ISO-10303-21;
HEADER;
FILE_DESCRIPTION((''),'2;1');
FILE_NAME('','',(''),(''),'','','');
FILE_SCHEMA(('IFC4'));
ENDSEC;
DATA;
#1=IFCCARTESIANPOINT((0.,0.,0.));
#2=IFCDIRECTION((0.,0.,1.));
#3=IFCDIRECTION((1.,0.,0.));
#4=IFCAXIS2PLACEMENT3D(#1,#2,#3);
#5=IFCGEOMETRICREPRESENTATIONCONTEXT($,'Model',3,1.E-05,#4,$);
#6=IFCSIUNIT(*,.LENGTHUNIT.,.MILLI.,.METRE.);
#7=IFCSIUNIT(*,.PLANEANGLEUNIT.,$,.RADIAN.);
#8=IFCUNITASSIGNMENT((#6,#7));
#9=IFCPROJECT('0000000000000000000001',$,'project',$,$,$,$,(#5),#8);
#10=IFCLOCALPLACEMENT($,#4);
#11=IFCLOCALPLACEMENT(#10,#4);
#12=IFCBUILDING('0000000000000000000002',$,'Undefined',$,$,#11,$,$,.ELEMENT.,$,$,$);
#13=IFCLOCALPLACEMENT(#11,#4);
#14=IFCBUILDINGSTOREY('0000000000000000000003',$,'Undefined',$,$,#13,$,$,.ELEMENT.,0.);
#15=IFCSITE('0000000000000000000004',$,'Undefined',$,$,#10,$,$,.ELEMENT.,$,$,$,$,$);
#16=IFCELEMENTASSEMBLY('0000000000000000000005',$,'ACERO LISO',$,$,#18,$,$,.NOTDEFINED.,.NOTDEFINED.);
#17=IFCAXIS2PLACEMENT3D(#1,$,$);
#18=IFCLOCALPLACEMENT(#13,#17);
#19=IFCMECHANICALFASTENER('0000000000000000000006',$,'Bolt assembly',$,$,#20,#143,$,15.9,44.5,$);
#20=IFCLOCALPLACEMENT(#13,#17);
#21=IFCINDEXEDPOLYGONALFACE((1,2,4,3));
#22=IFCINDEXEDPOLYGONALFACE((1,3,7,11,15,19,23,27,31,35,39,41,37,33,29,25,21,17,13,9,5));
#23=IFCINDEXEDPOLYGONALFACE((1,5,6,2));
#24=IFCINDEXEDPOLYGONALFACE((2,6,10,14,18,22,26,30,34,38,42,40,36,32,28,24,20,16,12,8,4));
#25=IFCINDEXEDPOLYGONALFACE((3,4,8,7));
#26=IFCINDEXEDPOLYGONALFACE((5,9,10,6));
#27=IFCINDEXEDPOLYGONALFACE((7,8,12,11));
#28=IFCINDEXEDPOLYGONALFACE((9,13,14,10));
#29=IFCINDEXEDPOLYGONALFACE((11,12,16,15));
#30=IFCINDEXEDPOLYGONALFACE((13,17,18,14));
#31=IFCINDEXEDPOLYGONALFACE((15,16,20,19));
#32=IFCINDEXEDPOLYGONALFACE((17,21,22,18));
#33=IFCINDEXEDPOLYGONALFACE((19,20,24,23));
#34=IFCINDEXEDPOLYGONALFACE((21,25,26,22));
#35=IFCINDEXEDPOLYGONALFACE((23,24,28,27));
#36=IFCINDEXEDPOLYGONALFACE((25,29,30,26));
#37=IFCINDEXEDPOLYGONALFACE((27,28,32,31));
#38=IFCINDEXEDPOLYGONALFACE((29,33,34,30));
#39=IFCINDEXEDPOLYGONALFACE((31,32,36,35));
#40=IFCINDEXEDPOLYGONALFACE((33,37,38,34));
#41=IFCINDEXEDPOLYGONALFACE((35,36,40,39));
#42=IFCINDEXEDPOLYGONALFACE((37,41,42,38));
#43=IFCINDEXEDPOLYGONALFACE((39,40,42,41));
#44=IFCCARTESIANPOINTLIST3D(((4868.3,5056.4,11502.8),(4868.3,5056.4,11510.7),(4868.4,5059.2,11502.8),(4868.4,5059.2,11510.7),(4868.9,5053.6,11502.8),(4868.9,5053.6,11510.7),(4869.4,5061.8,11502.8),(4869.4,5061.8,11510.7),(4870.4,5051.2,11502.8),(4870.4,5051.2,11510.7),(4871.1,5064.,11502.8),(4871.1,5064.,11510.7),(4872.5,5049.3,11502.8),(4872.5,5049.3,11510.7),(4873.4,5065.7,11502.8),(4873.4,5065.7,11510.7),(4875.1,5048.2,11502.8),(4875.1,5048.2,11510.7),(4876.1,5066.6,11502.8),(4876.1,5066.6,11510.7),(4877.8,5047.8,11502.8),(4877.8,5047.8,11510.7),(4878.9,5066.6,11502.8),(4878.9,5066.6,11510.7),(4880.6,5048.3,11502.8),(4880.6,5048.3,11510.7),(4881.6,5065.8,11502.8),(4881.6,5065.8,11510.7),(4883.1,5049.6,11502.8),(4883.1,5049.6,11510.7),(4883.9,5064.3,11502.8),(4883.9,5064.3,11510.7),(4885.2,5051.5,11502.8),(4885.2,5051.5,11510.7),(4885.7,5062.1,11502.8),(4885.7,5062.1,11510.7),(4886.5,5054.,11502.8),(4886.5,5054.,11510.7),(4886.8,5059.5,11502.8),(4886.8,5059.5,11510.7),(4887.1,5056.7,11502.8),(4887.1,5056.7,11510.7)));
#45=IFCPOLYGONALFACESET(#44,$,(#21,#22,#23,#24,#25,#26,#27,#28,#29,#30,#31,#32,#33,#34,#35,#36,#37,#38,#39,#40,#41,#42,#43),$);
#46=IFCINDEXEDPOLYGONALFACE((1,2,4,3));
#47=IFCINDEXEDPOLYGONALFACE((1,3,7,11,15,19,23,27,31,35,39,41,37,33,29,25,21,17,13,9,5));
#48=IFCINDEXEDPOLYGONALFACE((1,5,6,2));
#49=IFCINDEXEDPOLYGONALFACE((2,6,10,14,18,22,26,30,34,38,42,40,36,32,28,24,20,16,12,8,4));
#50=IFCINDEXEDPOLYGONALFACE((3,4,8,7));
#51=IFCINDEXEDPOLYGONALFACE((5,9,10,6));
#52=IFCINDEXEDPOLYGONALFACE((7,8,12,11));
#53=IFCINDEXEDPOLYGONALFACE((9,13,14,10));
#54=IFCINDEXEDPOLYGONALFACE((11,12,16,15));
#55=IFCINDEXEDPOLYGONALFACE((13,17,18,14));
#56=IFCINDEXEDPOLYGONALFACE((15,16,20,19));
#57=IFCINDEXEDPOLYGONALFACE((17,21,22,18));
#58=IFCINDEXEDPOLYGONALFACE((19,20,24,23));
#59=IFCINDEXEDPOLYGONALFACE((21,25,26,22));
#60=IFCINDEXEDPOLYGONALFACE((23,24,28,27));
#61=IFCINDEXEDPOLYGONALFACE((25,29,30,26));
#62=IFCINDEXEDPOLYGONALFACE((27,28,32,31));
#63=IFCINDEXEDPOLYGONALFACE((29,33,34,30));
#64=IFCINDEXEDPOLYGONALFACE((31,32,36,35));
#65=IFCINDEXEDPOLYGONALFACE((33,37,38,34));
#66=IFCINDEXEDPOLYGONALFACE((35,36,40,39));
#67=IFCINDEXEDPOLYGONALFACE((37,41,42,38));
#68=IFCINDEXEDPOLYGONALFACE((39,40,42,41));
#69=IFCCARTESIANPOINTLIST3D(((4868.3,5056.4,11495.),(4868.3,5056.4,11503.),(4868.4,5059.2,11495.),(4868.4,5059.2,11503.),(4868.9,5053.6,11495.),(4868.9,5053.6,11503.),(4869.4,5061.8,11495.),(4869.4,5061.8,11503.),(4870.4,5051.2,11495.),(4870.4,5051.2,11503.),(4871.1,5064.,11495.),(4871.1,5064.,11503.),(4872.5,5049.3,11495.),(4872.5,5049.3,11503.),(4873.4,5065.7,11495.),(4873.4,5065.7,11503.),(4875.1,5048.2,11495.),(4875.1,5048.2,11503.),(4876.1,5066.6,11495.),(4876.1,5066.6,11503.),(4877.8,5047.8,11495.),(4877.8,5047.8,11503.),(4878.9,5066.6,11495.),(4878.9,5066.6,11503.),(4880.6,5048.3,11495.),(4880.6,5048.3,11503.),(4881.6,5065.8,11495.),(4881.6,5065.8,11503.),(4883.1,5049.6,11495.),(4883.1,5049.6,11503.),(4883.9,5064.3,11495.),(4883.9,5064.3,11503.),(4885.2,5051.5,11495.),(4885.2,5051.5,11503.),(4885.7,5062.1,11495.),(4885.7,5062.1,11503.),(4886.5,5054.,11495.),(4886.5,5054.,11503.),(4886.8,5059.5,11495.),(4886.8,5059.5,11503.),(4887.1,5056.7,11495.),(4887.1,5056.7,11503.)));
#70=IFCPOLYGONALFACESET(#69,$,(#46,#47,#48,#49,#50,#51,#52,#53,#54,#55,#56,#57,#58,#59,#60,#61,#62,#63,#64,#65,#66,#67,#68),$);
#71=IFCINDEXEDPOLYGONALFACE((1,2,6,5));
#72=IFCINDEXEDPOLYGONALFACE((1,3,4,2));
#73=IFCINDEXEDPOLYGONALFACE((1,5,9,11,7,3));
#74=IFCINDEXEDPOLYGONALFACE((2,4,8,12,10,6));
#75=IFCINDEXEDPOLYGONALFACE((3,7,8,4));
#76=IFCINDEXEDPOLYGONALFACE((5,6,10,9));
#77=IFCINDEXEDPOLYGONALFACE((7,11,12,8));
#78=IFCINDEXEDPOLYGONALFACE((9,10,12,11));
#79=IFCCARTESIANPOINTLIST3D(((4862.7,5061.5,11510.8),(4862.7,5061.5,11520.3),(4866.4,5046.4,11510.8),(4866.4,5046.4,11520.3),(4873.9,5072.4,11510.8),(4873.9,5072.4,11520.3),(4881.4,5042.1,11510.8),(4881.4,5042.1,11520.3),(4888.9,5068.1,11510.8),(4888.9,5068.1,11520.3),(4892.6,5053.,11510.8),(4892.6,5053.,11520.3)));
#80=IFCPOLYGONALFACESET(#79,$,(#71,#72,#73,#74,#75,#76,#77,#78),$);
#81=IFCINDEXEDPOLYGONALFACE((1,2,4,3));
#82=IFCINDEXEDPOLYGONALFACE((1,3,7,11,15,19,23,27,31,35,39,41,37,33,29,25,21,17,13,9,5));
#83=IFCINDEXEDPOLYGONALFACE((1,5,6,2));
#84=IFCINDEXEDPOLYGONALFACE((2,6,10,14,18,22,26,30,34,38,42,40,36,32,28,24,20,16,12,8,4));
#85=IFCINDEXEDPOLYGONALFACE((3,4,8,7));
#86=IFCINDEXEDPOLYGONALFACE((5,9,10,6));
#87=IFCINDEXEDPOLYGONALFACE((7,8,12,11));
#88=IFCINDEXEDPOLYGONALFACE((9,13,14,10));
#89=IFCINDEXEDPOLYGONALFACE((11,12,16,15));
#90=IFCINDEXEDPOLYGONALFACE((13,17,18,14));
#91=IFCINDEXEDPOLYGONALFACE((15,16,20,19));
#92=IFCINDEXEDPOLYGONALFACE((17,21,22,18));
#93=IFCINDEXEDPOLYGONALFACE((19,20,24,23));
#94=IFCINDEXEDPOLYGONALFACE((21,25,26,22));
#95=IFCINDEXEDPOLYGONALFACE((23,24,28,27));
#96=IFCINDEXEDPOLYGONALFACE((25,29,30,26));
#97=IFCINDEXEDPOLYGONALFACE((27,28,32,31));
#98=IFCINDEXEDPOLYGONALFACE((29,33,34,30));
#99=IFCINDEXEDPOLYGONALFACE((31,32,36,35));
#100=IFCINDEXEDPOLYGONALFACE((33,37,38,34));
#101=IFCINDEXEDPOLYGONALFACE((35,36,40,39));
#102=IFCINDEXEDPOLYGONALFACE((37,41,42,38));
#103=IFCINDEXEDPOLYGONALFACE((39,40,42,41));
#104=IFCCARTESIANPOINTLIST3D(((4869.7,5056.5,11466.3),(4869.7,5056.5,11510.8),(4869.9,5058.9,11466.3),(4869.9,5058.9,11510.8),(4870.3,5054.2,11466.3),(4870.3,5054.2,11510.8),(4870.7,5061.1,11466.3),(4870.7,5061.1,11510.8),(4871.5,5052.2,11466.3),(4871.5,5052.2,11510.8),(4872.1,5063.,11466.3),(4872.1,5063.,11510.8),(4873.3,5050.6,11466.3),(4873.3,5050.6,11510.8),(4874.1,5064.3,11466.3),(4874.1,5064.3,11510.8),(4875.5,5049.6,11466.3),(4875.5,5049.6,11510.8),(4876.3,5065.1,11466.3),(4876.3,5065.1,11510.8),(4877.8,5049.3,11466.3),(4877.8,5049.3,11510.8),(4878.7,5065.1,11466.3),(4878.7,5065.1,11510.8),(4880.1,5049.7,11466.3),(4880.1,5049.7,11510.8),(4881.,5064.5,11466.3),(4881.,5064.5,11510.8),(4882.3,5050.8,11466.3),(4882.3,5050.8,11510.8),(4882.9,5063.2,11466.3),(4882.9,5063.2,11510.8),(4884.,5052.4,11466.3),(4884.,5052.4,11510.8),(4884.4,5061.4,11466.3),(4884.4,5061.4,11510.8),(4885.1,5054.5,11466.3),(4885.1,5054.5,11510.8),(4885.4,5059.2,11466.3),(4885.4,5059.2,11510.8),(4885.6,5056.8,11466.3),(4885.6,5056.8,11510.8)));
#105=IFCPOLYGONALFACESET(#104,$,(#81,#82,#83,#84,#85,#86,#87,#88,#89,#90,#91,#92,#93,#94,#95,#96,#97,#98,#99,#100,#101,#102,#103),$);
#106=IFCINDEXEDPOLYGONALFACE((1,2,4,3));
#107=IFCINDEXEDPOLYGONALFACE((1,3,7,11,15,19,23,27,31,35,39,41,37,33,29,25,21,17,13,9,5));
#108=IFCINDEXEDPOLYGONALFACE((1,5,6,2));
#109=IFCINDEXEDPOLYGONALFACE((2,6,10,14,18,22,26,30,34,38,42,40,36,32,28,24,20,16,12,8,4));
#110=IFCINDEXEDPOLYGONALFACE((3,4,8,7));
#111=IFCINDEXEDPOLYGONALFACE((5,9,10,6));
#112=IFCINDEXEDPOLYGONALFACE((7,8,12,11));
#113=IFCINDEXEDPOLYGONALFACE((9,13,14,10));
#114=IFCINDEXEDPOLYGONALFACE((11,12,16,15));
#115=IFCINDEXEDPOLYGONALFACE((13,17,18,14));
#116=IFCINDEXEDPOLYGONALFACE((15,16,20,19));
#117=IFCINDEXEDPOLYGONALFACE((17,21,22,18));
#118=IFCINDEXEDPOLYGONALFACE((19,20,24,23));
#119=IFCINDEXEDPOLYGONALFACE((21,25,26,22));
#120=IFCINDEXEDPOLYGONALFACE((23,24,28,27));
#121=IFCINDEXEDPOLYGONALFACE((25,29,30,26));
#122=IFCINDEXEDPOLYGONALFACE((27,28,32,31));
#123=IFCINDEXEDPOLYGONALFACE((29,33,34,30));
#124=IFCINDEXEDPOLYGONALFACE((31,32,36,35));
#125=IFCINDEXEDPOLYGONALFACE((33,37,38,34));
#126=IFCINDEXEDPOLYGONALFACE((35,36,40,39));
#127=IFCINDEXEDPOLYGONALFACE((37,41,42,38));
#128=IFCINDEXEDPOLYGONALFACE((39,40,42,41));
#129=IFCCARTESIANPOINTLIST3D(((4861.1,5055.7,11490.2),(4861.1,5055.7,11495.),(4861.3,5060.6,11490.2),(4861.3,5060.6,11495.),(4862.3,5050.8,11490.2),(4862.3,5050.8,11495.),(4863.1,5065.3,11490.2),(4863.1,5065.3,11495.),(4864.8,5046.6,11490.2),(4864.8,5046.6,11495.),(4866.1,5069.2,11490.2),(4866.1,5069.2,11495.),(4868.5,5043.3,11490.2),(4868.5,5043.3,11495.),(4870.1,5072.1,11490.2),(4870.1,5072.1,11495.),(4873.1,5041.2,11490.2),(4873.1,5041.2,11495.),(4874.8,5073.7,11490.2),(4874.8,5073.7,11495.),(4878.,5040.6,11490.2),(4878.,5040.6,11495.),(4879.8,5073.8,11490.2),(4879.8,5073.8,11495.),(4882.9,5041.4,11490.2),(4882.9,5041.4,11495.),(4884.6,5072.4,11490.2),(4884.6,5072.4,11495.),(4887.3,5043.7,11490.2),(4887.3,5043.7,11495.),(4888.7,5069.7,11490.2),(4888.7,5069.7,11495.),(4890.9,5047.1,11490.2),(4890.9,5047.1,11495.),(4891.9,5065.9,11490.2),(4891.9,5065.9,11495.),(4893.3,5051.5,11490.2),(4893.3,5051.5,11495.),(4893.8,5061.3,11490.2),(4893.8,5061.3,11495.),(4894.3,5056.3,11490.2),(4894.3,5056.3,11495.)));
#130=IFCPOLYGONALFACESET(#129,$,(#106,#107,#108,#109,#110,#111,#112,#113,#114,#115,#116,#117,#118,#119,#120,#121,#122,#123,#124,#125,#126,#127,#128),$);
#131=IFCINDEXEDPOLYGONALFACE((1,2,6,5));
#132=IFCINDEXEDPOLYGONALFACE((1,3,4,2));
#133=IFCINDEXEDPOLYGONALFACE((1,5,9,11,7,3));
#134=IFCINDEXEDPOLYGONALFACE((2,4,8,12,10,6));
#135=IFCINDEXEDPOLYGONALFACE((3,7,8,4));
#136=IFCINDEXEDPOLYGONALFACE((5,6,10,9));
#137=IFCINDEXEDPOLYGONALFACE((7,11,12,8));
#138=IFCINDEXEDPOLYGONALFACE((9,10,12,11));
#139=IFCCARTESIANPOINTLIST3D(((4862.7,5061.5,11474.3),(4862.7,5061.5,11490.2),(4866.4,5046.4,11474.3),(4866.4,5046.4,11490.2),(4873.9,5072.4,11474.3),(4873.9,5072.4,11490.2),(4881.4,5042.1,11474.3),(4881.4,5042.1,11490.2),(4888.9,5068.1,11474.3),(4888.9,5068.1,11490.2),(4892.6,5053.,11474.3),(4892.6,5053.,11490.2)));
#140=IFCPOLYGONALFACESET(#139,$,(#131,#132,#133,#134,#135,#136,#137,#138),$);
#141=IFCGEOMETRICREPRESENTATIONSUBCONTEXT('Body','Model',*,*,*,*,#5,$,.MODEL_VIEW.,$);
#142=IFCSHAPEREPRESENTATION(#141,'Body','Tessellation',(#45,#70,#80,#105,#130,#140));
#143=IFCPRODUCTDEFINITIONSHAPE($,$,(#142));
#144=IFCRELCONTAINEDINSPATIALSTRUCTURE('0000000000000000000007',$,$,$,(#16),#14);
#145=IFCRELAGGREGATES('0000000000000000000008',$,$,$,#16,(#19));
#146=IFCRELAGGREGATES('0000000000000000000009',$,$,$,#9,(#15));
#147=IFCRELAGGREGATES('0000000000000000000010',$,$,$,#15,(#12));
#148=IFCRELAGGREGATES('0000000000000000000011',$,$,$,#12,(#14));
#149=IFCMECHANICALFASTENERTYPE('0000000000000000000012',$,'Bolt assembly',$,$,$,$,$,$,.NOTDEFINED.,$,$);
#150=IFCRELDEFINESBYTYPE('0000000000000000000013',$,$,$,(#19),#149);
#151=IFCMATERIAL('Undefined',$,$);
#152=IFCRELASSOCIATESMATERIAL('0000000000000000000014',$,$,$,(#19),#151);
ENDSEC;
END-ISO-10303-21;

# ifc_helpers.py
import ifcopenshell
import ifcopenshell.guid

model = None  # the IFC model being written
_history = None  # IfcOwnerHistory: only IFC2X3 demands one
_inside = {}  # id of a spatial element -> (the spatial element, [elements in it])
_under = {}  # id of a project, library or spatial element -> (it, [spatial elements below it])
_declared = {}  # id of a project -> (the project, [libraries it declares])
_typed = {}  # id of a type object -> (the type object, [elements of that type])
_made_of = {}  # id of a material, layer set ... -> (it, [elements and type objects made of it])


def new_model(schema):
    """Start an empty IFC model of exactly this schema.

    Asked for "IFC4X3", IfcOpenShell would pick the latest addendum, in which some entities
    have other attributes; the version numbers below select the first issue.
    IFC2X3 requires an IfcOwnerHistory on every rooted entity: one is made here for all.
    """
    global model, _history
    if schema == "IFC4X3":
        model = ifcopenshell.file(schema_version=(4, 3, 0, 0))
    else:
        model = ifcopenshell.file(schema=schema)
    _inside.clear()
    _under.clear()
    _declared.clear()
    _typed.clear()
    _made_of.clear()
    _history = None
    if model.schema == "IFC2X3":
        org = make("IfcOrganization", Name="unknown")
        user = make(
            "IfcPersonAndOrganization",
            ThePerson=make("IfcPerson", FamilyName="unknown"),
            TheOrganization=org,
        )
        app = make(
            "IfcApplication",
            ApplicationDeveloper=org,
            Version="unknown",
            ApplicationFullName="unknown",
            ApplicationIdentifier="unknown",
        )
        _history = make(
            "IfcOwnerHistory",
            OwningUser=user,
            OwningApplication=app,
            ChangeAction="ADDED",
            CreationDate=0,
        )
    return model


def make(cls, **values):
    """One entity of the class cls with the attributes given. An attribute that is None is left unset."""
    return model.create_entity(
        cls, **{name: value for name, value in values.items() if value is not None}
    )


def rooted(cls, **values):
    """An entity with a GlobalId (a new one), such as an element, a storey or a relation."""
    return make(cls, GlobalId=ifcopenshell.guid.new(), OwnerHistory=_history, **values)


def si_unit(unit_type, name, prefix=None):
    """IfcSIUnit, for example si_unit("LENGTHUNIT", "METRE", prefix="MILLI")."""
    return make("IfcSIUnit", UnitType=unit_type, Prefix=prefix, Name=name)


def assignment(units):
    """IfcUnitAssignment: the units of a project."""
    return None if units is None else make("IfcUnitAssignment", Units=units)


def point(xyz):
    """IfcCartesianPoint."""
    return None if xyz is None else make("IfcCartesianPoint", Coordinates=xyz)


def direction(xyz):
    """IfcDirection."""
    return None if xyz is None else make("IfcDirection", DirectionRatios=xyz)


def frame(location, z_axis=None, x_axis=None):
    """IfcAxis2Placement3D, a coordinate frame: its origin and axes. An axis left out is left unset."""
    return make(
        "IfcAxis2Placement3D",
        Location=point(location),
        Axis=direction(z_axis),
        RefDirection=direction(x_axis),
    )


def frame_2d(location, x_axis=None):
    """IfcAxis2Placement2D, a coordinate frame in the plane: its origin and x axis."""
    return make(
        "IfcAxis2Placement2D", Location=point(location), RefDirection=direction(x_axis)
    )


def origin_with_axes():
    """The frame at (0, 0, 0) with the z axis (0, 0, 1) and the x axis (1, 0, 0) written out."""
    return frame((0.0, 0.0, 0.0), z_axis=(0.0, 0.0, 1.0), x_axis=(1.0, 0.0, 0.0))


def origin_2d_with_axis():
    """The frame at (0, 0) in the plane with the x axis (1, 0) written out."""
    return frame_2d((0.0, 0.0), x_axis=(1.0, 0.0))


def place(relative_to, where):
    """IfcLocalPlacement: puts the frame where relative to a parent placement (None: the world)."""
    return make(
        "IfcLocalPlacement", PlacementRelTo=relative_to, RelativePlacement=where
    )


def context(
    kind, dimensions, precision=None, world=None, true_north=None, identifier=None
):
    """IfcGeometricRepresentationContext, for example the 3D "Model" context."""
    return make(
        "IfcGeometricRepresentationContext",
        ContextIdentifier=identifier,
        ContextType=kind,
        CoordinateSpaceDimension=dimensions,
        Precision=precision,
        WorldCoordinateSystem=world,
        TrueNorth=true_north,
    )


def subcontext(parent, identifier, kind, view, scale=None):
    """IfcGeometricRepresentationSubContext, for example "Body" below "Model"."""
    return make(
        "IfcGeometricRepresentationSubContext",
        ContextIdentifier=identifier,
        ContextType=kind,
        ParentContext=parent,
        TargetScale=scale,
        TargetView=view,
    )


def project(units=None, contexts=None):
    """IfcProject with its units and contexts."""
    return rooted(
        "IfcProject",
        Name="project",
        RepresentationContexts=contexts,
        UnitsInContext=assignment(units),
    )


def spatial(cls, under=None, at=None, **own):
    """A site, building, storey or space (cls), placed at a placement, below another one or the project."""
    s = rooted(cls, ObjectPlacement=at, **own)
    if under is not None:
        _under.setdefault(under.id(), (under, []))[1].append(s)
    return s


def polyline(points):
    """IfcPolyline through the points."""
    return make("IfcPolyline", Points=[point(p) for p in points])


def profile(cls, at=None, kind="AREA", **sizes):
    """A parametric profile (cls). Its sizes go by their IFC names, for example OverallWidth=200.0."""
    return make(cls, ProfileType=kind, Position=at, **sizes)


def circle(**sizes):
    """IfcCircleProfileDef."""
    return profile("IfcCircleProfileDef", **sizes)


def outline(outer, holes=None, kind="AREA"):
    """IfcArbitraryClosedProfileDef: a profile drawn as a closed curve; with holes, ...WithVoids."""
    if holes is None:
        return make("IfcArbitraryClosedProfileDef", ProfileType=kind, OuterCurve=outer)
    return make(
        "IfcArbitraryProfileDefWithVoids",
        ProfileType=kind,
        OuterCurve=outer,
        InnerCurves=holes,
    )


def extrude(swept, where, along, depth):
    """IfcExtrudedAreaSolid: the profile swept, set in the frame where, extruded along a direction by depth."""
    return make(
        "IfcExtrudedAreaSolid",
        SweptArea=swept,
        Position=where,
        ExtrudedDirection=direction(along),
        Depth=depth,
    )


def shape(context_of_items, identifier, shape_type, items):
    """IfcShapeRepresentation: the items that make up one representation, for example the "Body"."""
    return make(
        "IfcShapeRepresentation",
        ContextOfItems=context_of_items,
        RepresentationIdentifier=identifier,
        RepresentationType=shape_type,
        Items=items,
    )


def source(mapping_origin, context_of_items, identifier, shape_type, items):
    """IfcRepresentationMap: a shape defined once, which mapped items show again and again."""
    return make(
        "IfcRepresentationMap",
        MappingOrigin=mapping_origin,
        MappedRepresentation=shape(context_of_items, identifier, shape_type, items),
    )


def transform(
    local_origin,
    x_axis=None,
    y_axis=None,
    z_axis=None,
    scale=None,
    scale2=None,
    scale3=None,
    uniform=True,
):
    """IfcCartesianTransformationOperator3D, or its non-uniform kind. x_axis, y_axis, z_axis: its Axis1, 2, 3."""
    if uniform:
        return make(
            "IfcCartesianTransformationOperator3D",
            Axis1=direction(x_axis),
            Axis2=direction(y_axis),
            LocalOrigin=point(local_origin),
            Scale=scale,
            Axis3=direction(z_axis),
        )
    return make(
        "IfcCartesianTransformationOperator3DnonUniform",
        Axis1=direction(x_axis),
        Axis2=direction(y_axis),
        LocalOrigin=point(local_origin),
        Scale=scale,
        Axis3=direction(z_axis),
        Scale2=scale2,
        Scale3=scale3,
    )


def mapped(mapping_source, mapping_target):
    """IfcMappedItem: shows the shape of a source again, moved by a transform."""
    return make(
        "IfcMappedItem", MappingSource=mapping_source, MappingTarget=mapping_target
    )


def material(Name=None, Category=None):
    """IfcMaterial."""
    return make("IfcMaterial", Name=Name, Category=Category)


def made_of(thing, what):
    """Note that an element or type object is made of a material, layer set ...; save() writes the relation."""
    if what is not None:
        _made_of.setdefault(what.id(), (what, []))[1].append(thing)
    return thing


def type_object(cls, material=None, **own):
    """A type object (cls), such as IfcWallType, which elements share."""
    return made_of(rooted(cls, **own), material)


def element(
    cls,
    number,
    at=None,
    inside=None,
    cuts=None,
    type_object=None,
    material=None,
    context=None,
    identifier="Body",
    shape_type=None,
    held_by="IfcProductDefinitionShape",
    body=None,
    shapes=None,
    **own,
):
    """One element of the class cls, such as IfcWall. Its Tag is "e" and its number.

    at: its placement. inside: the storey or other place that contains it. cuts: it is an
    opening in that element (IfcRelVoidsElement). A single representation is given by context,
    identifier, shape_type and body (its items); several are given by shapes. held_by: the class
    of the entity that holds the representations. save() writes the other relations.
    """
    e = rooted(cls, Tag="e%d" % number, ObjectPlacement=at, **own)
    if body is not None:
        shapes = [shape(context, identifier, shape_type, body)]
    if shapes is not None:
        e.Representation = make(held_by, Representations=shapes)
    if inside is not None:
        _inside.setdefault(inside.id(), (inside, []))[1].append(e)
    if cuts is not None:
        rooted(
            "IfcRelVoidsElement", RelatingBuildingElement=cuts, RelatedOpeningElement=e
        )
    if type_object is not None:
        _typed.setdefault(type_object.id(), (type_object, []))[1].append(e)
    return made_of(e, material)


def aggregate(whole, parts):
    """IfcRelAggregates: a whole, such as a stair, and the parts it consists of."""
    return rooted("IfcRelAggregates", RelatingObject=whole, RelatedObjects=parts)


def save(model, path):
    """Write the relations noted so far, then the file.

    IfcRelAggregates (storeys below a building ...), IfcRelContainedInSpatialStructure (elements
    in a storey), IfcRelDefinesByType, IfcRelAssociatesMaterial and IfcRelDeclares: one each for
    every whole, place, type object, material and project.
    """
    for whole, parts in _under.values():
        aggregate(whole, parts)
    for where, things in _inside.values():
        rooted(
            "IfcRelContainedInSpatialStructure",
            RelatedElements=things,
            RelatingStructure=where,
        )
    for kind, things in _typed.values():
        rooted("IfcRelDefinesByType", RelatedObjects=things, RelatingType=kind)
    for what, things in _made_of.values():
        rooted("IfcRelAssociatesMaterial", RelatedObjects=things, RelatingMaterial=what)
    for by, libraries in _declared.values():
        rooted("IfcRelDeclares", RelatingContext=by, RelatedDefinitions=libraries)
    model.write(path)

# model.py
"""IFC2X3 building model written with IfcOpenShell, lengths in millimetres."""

from ifc_helpers import new_model, si_unit, frame, origin_with_axes, origin_2d_with_axis, place, context, subcontext, project, spatial, polyline, circle, outline, extrude, source, transform, mapped, material, type_object, element, aggregate, save


model = new_model("IFC2X3")

# Units and contexts
model_context = context("Model", 3, precision=1e-05, world=origin_with_axes())
body_context = subcontext(model_context, "Body", "Model", "MODEL_VIEW")
ifc_project = project(units=[si_unit("LENGTHUNIT", "METRE", prefix="MILLI"), si_unit("PLANEANGLEUNIT", "RADIAN")], contexts=[model_context])

# Site, building, storey
site_placement = place(None, origin_with_axes())
site = spatial("IfcSite", under=ifc_project, at=site_placement, Name="Undefined", CompositionType="ELEMENT")
building_placement = place(site_placement, origin_with_axes())
building = spatial("IfcBuilding", under=site, at=building_placement, Name="Undefined", CompositionType="ELEMENT")
storey_placement = place(building_placement, origin_with_axes())
storey = spatial("IfcBuildingStorey", under=building, at=storey_placement, Name="Undefined", CompositionType="ELEMENT", Elevation=0.0)

# Element assembly
assembly_1_placement = place(storey_placement, origin_with_axes())
assembly_1 = element("IfcElementAssembly", 1, at=assembly_1_placement, inside=storey, Name="ACERO LISO", AssemblyPlace="NOTDEFINED", PredefinedType="NOTDEFINED")

# Mechanical fastener
ifc_material_1 = material(Name="Undefined")
mechanical_fastener_type = type_object("IfcMechanicalFastenerType", Name="Bolt assembly")
shared_shape_1 = source(origin_with_axes(), body_context, "Body", "SweptSolid", [
    extrude(circle(Radius=9.4, at=origin_2d_with_axis()), frame((0.0, -11.7, 0.0), z_axis=(0.0, 1.0, 0.0), x_axis=(1.0, 0.0, 0.0)), (0.0, 0.0, 1.0), 7.9),
    extrude(circle(Radius=9.4, at=origin_2d_with_axis()), frame((0.0, -4.0, 0.0), z_axis=(0.0, 1.0, 0.0), x_axis=(1.0, 0.0, 0.0)), (0.0, 0.0, 1.0), 8.0),
    extrude(outline(polyline([(13.5, -7.8), (13.5, 7.8), (0.0, 15.6), (-13.5, 7.8), (-13.5, -7.8), (0.0, -15.6), (13.5, -7.8)])), frame((0.0, -21.4, 0.0), z_axis=(0.0, 1.0, 0.0), x_axis=(1.0, 0.0, 0.0)), (0.0, 0.0, 1.0), 9.5),
    extrude(circle(Radius=7.9, at=origin_2d_with_axis()), frame((0.0, -11.8, 0.0), z_axis=(0.0, 1.0, 0.0), x_axis=(1.0, 0.0, 0.0)), (0.0, 0.0, 1.0), 44.5),
    extrude(circle(Radius=16.7, at=origin_2d_with_axis()), frame((0.0, 4.0, 0.0), z_axis=(0.0, 1.0, 0.0), x_axis=(1.0, 0.0, 0.0)), (0.0, 0.0, 1.0), 4.8),
    extrude(outline(polyline([(13.5, -7.8), (13.5, 7.8), (0.0, 15.6), (-13.5, 7.8), (-13.5, -7.8), (0.0, -15.6), (13.5, -7.8)])), frame((0.0, 8.7, 0.0), z_axis=(0.0, 1.0, 0.0), x_axis=(1.0, 0.0, 0.0)), (0.0, 0.0, 1.0), 15.9),
])
mechanical_fastener_1_placement = place(assembly_1_placement, frame((4877.7, 5057.2, 11498.9), z_axis=(-0.719013, -0.694997, 0.0), x_axis=(-0.694997, 0.719013, 0.0)))
mechanical_fastener_1 = element("IfcMechanicalFastener", 2, at=mechanical_fastener_1_placement, type_object=mechanical_fastener_type, material=ifc_material_1, Name="Bolt assembly", NominalDiameter=15.9, NominalLength=44.5, context=body_context, shape_type="MappedRepresentation", body=[
    mapped(shared_shape_1, transform((0.0, 0.0, 0.0))),
])
aggregate(assembly_1, [mechanical_fastener_1])

save(model, "model.ifc")
